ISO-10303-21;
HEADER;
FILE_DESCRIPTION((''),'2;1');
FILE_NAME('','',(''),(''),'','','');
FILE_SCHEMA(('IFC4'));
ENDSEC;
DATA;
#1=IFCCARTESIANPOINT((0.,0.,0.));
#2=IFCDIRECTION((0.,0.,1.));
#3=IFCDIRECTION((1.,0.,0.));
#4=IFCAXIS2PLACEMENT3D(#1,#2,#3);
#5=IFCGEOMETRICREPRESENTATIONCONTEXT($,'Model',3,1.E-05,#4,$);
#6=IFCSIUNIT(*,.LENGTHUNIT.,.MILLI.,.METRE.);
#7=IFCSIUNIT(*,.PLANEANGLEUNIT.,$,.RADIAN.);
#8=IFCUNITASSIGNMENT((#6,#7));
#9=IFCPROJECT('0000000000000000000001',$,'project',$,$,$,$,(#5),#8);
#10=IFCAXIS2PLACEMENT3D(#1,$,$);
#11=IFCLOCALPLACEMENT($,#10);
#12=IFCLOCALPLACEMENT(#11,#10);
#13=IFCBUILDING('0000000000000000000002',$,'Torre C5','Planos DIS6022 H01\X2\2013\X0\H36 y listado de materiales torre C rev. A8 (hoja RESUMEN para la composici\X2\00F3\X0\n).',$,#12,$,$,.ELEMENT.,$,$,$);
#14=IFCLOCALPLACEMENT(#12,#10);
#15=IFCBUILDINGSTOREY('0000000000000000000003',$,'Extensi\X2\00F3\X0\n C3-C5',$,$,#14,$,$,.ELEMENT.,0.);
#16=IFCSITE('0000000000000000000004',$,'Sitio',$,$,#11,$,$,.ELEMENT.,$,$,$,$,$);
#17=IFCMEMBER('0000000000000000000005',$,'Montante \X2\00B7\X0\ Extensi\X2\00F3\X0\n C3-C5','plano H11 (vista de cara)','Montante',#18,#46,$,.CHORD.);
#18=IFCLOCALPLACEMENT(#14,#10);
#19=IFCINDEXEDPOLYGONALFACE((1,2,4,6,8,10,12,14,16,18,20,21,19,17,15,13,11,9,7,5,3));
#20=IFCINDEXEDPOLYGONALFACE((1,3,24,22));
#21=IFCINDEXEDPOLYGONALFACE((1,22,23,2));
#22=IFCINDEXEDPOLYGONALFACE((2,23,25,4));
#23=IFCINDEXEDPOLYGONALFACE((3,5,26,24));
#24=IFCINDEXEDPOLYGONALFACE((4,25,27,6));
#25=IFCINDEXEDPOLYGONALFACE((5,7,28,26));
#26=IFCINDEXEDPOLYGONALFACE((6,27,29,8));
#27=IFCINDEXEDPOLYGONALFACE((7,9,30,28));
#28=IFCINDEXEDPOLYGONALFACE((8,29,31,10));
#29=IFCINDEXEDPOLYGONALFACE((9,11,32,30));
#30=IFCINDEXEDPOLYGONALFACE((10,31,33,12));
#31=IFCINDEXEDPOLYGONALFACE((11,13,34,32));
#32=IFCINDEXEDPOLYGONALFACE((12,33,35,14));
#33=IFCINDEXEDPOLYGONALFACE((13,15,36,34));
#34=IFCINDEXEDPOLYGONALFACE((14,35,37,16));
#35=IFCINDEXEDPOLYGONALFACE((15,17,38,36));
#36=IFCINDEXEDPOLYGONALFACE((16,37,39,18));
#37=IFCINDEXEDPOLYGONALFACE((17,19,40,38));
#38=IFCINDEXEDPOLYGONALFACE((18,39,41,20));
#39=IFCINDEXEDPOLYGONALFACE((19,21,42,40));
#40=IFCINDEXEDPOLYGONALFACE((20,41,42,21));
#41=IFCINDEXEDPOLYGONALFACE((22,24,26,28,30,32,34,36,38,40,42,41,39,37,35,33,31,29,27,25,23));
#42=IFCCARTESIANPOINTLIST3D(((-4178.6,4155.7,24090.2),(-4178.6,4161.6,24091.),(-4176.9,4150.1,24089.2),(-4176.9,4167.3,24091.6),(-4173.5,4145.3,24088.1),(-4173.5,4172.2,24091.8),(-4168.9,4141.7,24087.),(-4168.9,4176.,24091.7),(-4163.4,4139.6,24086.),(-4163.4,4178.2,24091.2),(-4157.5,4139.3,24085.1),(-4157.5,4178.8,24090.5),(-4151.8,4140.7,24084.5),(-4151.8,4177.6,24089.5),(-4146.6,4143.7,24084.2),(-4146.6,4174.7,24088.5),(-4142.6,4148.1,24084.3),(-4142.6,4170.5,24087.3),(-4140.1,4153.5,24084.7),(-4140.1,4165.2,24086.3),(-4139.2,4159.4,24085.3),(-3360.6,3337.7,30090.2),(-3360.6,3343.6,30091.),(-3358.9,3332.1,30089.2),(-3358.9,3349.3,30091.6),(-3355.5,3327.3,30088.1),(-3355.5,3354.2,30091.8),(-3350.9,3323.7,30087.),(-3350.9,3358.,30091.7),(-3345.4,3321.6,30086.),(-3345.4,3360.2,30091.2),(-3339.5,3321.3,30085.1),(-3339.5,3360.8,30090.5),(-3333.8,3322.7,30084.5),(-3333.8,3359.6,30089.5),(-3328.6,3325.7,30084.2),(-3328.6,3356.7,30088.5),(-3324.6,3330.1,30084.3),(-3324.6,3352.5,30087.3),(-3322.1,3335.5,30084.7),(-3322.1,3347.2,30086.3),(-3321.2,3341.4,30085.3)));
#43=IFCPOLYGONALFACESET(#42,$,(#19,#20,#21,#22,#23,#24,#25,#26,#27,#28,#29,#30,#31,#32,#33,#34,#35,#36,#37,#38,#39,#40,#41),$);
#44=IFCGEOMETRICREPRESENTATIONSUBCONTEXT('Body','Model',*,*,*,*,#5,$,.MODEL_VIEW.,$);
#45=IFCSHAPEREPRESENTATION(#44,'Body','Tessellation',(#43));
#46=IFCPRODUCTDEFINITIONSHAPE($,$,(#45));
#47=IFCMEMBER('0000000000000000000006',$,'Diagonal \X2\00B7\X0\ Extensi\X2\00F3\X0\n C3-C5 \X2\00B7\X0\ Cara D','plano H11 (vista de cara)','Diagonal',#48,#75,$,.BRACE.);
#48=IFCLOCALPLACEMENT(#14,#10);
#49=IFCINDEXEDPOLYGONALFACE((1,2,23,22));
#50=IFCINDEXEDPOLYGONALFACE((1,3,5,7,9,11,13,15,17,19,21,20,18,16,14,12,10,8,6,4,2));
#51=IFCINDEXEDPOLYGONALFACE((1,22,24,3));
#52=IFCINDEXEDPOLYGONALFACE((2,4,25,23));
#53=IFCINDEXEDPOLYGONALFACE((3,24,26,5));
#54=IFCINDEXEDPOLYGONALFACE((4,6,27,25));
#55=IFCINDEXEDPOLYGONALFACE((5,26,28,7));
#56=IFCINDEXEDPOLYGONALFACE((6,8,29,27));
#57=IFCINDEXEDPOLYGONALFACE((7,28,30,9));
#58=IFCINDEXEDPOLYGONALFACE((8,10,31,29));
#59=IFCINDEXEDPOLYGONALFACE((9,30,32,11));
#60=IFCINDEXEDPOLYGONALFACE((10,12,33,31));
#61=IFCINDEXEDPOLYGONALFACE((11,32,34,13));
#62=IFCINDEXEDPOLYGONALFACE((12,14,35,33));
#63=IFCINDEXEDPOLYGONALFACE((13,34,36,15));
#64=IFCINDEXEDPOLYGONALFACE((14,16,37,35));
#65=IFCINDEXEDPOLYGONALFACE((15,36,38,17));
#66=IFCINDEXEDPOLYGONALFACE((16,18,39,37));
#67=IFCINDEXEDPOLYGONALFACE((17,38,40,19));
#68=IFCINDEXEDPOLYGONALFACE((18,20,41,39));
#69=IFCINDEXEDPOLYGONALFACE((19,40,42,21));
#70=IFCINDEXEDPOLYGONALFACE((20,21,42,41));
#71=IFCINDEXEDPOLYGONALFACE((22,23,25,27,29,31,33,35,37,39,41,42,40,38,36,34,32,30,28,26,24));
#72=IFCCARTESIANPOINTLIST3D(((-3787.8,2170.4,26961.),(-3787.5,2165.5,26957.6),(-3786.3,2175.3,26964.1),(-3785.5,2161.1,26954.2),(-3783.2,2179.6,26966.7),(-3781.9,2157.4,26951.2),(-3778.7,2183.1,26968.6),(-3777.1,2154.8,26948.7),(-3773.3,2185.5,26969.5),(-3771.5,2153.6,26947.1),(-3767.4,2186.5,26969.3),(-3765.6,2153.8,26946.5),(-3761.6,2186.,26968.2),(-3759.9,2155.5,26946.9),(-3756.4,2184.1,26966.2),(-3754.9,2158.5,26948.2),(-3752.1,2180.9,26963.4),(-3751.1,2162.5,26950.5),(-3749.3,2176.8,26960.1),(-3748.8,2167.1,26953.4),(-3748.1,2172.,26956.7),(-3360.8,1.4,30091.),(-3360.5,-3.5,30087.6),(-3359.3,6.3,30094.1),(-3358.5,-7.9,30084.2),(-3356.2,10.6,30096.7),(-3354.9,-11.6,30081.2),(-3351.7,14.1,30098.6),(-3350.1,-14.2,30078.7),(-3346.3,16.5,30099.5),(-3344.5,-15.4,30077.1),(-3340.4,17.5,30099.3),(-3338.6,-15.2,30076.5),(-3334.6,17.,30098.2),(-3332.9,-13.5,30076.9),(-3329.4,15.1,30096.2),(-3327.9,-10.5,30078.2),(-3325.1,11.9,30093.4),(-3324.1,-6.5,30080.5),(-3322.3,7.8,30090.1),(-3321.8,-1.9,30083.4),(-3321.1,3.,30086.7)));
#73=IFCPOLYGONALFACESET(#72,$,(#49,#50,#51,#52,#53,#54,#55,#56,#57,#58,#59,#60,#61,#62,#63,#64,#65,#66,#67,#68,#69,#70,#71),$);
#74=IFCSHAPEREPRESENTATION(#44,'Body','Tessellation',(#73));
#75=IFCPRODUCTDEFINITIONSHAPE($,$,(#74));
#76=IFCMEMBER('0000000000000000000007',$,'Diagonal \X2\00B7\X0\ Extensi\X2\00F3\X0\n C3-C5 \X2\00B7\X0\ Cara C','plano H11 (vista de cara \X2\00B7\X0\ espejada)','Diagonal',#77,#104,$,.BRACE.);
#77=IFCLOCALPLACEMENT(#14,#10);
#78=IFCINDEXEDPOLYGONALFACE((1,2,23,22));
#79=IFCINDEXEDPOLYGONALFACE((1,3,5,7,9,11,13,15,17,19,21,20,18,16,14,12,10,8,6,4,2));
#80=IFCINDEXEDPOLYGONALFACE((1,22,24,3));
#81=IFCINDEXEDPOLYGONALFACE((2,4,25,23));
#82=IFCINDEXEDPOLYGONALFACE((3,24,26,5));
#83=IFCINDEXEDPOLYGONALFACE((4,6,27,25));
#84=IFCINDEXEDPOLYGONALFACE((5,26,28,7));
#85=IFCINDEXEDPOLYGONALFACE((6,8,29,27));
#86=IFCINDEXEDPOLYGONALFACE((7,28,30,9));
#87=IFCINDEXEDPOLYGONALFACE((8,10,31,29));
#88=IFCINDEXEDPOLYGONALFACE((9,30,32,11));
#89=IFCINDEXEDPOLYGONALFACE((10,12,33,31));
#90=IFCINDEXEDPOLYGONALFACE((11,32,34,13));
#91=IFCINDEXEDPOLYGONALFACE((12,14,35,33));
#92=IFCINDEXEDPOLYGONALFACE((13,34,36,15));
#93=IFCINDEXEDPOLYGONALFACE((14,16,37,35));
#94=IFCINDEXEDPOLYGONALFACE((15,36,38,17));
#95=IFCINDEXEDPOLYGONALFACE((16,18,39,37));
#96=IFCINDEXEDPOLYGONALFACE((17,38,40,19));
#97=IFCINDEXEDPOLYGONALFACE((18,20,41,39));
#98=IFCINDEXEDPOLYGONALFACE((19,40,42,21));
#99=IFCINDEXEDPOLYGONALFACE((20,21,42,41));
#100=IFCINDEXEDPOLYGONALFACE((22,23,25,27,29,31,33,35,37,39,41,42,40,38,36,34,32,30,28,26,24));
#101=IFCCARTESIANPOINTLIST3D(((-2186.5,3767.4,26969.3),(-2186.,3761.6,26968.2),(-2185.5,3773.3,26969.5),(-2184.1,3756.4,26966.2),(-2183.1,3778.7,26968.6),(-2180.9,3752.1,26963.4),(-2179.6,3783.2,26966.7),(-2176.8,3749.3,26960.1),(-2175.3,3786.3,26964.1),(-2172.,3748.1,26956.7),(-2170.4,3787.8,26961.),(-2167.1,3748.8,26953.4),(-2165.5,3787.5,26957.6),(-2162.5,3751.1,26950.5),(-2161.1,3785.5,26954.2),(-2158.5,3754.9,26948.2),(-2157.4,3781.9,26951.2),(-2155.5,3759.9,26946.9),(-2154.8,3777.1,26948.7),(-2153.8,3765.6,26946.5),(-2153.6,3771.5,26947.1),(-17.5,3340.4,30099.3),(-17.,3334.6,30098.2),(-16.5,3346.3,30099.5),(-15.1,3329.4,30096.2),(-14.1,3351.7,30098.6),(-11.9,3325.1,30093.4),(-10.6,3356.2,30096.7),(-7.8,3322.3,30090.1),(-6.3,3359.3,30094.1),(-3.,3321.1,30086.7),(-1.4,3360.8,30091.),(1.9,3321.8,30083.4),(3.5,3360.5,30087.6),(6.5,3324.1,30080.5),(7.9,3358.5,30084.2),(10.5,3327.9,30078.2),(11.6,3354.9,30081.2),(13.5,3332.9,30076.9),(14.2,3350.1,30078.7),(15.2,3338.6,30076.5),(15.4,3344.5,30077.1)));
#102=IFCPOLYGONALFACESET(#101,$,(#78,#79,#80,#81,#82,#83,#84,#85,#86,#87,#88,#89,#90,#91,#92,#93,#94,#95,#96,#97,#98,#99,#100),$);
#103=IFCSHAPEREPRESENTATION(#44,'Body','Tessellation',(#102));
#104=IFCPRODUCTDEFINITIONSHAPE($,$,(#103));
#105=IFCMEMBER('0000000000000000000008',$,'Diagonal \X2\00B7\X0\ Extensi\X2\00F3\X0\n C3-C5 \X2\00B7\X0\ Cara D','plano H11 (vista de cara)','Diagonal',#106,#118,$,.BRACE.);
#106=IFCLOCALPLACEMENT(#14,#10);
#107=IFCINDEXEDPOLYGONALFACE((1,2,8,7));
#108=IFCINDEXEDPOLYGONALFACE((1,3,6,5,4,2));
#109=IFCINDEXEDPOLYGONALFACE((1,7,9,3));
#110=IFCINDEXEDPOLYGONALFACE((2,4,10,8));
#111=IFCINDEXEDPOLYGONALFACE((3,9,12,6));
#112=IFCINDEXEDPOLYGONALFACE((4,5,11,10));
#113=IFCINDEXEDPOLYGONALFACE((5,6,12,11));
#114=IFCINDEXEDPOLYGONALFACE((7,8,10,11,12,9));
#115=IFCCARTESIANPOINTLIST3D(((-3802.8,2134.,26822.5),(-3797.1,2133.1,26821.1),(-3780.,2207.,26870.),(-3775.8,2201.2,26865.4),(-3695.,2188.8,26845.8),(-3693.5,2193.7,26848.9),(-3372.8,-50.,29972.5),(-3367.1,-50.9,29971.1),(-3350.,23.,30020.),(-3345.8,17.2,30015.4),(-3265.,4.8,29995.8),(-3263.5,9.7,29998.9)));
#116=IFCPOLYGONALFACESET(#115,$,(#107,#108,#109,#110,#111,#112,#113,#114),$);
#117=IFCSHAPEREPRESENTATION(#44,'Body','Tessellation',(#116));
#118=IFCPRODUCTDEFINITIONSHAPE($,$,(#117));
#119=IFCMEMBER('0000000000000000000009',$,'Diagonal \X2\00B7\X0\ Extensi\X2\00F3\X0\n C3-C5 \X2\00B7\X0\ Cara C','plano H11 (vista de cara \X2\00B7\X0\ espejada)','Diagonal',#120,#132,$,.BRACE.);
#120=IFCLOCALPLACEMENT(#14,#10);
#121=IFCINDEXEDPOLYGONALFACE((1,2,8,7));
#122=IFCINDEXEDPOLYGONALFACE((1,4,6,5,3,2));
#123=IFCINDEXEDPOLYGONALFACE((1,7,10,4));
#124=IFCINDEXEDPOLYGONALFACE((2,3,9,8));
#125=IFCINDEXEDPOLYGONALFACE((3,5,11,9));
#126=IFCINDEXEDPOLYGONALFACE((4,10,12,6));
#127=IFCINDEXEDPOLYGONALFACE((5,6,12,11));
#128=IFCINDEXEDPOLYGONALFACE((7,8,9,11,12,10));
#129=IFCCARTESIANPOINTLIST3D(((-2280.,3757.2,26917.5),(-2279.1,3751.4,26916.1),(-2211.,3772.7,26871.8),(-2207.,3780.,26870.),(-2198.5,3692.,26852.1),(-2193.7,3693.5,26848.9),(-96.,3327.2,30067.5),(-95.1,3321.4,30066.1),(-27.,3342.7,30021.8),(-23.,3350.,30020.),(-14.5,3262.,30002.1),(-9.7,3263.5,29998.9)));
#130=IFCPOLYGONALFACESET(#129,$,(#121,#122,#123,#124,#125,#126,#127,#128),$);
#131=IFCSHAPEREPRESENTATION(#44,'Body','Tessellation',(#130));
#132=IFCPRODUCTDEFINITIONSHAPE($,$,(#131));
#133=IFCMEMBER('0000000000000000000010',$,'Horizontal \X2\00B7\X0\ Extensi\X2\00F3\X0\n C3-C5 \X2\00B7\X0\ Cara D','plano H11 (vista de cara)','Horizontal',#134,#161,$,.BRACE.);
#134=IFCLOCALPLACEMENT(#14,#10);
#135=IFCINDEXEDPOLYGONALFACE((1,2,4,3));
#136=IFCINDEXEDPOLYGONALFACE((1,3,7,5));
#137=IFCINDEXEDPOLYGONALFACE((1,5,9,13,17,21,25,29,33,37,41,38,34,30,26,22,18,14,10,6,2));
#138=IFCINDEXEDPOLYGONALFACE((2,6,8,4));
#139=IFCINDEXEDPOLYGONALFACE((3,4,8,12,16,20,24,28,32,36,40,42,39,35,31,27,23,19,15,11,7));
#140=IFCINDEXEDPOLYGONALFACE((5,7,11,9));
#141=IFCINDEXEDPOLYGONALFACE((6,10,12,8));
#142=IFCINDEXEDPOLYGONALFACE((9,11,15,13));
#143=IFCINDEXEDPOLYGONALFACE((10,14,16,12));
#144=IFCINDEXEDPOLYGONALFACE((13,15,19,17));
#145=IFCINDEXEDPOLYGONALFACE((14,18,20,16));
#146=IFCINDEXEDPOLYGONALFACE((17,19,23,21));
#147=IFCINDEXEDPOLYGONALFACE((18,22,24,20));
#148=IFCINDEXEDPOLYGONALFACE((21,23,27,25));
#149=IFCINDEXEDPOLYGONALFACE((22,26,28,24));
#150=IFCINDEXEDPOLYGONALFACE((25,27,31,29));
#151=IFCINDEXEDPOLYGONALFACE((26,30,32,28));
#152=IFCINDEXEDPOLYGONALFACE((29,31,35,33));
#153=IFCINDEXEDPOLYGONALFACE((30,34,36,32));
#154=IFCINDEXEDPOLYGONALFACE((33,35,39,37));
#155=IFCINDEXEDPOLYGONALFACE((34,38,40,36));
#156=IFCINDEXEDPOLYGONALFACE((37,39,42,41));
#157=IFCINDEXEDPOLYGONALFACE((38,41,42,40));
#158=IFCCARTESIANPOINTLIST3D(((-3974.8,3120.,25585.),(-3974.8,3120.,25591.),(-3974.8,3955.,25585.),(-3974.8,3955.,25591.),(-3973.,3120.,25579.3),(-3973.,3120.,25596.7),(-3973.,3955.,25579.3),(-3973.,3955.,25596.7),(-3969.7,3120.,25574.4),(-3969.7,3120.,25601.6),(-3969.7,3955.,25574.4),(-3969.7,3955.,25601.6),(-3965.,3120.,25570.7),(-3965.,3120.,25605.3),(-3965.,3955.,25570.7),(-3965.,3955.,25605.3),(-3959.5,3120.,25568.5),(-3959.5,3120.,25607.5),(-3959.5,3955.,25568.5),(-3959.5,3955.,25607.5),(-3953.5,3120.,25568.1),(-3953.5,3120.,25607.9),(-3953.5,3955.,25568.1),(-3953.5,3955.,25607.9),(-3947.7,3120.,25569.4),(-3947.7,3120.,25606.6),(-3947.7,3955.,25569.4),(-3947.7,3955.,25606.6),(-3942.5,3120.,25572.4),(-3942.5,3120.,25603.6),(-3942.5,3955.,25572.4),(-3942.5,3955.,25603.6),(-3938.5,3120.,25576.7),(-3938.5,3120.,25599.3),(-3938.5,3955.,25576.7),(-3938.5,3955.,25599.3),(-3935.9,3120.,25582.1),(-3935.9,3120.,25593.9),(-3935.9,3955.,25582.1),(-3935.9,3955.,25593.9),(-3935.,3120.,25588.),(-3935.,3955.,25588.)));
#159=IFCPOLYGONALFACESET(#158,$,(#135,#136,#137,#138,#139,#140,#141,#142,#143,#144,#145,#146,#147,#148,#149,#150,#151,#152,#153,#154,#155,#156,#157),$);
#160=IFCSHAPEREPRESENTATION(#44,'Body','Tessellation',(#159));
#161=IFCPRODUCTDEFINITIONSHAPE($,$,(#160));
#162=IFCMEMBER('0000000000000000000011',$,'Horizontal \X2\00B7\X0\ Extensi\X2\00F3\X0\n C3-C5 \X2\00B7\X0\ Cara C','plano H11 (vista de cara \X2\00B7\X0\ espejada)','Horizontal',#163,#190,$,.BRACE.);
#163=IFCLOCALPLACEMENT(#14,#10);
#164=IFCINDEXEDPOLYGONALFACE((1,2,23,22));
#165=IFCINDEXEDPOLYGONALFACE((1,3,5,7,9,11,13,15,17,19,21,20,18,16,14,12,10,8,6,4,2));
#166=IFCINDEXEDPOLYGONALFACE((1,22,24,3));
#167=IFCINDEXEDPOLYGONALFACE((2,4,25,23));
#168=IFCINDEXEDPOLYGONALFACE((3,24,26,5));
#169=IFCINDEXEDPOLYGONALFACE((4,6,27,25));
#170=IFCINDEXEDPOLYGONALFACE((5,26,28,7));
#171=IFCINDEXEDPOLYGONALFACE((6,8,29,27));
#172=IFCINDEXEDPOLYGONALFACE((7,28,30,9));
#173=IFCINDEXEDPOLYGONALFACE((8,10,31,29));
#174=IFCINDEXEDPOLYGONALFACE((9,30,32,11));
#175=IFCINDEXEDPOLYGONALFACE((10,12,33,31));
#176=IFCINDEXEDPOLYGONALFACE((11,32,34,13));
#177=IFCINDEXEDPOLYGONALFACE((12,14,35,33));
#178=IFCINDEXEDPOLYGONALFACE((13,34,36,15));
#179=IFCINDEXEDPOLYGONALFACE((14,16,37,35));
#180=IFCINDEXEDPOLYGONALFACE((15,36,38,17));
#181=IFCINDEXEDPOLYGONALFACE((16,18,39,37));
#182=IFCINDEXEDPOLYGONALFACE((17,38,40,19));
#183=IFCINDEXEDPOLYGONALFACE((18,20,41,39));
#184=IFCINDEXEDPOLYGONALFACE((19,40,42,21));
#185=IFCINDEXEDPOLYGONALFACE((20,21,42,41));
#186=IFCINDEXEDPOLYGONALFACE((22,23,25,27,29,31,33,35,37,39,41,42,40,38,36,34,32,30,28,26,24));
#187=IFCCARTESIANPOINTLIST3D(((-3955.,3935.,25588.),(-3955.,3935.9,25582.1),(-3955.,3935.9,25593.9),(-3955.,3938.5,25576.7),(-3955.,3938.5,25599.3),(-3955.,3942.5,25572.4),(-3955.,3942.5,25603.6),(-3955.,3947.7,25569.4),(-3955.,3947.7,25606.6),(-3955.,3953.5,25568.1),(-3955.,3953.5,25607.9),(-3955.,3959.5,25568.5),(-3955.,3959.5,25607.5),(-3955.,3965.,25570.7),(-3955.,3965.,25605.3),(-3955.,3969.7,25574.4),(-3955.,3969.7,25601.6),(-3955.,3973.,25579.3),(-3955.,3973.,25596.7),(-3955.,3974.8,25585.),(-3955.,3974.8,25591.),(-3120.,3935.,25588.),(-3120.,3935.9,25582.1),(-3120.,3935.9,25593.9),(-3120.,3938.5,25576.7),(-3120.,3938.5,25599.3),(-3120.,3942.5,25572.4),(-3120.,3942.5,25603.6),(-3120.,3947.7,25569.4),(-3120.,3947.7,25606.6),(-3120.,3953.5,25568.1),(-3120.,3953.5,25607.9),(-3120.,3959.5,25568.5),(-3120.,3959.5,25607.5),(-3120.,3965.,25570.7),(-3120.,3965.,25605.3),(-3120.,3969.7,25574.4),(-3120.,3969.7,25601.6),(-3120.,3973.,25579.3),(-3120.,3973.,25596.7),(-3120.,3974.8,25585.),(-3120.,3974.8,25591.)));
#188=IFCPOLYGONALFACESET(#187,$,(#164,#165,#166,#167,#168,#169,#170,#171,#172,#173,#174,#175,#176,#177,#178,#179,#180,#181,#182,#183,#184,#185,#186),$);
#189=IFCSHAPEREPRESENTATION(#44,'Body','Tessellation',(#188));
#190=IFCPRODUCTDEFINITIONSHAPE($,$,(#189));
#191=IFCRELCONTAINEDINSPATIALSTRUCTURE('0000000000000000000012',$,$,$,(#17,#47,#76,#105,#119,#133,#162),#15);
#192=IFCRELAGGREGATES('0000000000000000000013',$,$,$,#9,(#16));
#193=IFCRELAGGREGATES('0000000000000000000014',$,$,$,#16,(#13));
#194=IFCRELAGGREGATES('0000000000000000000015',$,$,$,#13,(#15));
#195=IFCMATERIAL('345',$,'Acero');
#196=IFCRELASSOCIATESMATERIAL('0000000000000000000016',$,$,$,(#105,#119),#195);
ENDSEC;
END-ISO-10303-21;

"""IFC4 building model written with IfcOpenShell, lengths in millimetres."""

from ifc_helpers import new_model, si_unit, frame, frame_2d, origin, origin_with_axes, place, context, subcontext, project, spatial, circle, l_section, extrude, material, element, save


model = new_model("IFC4")

# Units and contexts
model_context = context("Model", 3, precision=1e-05, world=origin_with_axes())
body_context = subcontext(model_context, "Body", "Model", "MODEL_VIEW")
ifc_project = project(units=[si_unit("LENGTHUNIT", "METRE", prefix="MILLI"), si_unit("PLANEANGLEUNIT", "RADIAN")], contexts=[model_context])

# Site, building, storey
site_placement = place(None, origin())
site = spatial("IfcSite", under=ifc_project, at=site_placement, Name="Sitio", CompositionType="ELEMENT")
building_placement = place(site_placement, origin())
building = spatial("IfcBuilding", under=site, at=building_placement, Name="Torre C5", Description="Planos DIS6022 H01–H36 y listado de materiales torre C rev. A8 (hoja RESUMEN para la composición).", CompositionType="ELEMENT")
storey_placement = place(building_placement, origin())
storey = spatial("IfcBuildingStorey", under=building, at=storey_placement, Name="Extensión C3-C5", CompositionType="ELEMENT", Elevation=0.0)

# Members
member_placement = place(storey_placement, frame((-3341.0, 3341.0, 30088.0), z_axis=(-0.133868, 0.133868, -0.981916), x_axis=(0.990999, 0.018083, -0.132641)))
element("IfcMember", 1, at=member_placement, inside=storey, Name="Montante · Extensión C3-C5", Description="plano H11 (vista de cara)", ObjectType="Montante", PredefinedType="CHORD", context=body_context, shape_type="SweptSolid", body=[
    extrude(circle(Radius=20.0), None, (0.0, 0.0, 1.0), 6110.5),
])
for number, where, z_axis, x_axis, name, description in (
    (2, (-3341.0, 1.0, 30088.0), (-0.111432, 0.566031, -0.816818), (0.962353, -0.14358, -0.230783), "Diagonal · Extensión C3-C5 · Cara D", "plano H11 (vista de cara)"),
    (3, (-1.0, 3341.0, 30088.0), (-0.566031, 0.111432, -0.816818), (0.14358, -0.962353, -0.230783), "Diagonal · Extensión C3-C5 · Cara C", "plano H11 (vista de cara · espejada)"),
):
    element("IfcMember", number, at=place(storey_placement, frame(where, z_axis=z_axis, x_axis=x_axis)), inside=storey, Name=name, Description=description, ObjectType="Diagonal", PredefinedType="BRACE", context=body_context, shape_type="SweptSolid", body=[
        extrude(circle(Radius=20.0), None, (0.0, 0.0, 1.0), 3831.9),
    ])
ifc_material_1 = material(Name="345", Category="Acero")
for number, where, z_axis, x_axis, name, description in (
    (4, (-3350.0, 23.0, 30020.0), (-0.111483, 0.566228, -0.816675), (0.960867, -0.148288, -0.233979), "Diagonal · Extensión C3-C5 · Cara D", "plano H11 (vista de cara)"),
    (5, (-23.0, 3350.0, 30020.0), (-0.566228, 0.111483, -0.816675), (0.148288, -0.960867, -0.233979), "Diagonal · Extensión C3-C5 · Cara C", "plano H11 (vista de cara · espejada)"),
):
    element("IfcMember", number, at=place(storey_placement, frame(where, z_axis=z_axis, x_axis=x_axis)), inside=storey, material=ifc_material_1, Name=name, Description=description, ObjectType="Diagonal", PredefinedType="BRACE", context=body_context, shape_type="SweptSolid", body=[
        extrude(l_section(Depth=90.0, Width=90.0, Thickness=6.0, at=frame_2d((45.0, 45.0))), None, (0.0, 0.0, 1.0), 3857.1),
    ])
for number, where, z_axis, x_axis, name, description in (
    (6, (-3955.0, 3120.0, 25588.0), (0.0, 1.0, 0.0), (1.0, 0.0, 0.0), "Horizontal · Extensión C3-C5 · Cara D", "plano H11 (vista de cara)"),
    (7, (-3120.0, 3955.0, 25588.0), (-1.0, 0.0, 0.0), (0.0, -1.0, 0.0), "Horizontal · Extensión C3-C5 · Cara C", "plano H11 (vista de cara · espejada)"),
):
    element("IfcMember", number, at=place(storey_placement, frame(where, z_axis=z_axis, x_axis=x_axis)), inside=storey, Name=name, Description=description, ObjectType="Horizontal", PredefinedType="BRACE", context=body_context, shape_type="SweptSolid", body=[
        extrude(circle(Radius=20.0), None, (0.0, 0.0, 1.0), 835.0),
    ])

save(model, "model.ifc")
